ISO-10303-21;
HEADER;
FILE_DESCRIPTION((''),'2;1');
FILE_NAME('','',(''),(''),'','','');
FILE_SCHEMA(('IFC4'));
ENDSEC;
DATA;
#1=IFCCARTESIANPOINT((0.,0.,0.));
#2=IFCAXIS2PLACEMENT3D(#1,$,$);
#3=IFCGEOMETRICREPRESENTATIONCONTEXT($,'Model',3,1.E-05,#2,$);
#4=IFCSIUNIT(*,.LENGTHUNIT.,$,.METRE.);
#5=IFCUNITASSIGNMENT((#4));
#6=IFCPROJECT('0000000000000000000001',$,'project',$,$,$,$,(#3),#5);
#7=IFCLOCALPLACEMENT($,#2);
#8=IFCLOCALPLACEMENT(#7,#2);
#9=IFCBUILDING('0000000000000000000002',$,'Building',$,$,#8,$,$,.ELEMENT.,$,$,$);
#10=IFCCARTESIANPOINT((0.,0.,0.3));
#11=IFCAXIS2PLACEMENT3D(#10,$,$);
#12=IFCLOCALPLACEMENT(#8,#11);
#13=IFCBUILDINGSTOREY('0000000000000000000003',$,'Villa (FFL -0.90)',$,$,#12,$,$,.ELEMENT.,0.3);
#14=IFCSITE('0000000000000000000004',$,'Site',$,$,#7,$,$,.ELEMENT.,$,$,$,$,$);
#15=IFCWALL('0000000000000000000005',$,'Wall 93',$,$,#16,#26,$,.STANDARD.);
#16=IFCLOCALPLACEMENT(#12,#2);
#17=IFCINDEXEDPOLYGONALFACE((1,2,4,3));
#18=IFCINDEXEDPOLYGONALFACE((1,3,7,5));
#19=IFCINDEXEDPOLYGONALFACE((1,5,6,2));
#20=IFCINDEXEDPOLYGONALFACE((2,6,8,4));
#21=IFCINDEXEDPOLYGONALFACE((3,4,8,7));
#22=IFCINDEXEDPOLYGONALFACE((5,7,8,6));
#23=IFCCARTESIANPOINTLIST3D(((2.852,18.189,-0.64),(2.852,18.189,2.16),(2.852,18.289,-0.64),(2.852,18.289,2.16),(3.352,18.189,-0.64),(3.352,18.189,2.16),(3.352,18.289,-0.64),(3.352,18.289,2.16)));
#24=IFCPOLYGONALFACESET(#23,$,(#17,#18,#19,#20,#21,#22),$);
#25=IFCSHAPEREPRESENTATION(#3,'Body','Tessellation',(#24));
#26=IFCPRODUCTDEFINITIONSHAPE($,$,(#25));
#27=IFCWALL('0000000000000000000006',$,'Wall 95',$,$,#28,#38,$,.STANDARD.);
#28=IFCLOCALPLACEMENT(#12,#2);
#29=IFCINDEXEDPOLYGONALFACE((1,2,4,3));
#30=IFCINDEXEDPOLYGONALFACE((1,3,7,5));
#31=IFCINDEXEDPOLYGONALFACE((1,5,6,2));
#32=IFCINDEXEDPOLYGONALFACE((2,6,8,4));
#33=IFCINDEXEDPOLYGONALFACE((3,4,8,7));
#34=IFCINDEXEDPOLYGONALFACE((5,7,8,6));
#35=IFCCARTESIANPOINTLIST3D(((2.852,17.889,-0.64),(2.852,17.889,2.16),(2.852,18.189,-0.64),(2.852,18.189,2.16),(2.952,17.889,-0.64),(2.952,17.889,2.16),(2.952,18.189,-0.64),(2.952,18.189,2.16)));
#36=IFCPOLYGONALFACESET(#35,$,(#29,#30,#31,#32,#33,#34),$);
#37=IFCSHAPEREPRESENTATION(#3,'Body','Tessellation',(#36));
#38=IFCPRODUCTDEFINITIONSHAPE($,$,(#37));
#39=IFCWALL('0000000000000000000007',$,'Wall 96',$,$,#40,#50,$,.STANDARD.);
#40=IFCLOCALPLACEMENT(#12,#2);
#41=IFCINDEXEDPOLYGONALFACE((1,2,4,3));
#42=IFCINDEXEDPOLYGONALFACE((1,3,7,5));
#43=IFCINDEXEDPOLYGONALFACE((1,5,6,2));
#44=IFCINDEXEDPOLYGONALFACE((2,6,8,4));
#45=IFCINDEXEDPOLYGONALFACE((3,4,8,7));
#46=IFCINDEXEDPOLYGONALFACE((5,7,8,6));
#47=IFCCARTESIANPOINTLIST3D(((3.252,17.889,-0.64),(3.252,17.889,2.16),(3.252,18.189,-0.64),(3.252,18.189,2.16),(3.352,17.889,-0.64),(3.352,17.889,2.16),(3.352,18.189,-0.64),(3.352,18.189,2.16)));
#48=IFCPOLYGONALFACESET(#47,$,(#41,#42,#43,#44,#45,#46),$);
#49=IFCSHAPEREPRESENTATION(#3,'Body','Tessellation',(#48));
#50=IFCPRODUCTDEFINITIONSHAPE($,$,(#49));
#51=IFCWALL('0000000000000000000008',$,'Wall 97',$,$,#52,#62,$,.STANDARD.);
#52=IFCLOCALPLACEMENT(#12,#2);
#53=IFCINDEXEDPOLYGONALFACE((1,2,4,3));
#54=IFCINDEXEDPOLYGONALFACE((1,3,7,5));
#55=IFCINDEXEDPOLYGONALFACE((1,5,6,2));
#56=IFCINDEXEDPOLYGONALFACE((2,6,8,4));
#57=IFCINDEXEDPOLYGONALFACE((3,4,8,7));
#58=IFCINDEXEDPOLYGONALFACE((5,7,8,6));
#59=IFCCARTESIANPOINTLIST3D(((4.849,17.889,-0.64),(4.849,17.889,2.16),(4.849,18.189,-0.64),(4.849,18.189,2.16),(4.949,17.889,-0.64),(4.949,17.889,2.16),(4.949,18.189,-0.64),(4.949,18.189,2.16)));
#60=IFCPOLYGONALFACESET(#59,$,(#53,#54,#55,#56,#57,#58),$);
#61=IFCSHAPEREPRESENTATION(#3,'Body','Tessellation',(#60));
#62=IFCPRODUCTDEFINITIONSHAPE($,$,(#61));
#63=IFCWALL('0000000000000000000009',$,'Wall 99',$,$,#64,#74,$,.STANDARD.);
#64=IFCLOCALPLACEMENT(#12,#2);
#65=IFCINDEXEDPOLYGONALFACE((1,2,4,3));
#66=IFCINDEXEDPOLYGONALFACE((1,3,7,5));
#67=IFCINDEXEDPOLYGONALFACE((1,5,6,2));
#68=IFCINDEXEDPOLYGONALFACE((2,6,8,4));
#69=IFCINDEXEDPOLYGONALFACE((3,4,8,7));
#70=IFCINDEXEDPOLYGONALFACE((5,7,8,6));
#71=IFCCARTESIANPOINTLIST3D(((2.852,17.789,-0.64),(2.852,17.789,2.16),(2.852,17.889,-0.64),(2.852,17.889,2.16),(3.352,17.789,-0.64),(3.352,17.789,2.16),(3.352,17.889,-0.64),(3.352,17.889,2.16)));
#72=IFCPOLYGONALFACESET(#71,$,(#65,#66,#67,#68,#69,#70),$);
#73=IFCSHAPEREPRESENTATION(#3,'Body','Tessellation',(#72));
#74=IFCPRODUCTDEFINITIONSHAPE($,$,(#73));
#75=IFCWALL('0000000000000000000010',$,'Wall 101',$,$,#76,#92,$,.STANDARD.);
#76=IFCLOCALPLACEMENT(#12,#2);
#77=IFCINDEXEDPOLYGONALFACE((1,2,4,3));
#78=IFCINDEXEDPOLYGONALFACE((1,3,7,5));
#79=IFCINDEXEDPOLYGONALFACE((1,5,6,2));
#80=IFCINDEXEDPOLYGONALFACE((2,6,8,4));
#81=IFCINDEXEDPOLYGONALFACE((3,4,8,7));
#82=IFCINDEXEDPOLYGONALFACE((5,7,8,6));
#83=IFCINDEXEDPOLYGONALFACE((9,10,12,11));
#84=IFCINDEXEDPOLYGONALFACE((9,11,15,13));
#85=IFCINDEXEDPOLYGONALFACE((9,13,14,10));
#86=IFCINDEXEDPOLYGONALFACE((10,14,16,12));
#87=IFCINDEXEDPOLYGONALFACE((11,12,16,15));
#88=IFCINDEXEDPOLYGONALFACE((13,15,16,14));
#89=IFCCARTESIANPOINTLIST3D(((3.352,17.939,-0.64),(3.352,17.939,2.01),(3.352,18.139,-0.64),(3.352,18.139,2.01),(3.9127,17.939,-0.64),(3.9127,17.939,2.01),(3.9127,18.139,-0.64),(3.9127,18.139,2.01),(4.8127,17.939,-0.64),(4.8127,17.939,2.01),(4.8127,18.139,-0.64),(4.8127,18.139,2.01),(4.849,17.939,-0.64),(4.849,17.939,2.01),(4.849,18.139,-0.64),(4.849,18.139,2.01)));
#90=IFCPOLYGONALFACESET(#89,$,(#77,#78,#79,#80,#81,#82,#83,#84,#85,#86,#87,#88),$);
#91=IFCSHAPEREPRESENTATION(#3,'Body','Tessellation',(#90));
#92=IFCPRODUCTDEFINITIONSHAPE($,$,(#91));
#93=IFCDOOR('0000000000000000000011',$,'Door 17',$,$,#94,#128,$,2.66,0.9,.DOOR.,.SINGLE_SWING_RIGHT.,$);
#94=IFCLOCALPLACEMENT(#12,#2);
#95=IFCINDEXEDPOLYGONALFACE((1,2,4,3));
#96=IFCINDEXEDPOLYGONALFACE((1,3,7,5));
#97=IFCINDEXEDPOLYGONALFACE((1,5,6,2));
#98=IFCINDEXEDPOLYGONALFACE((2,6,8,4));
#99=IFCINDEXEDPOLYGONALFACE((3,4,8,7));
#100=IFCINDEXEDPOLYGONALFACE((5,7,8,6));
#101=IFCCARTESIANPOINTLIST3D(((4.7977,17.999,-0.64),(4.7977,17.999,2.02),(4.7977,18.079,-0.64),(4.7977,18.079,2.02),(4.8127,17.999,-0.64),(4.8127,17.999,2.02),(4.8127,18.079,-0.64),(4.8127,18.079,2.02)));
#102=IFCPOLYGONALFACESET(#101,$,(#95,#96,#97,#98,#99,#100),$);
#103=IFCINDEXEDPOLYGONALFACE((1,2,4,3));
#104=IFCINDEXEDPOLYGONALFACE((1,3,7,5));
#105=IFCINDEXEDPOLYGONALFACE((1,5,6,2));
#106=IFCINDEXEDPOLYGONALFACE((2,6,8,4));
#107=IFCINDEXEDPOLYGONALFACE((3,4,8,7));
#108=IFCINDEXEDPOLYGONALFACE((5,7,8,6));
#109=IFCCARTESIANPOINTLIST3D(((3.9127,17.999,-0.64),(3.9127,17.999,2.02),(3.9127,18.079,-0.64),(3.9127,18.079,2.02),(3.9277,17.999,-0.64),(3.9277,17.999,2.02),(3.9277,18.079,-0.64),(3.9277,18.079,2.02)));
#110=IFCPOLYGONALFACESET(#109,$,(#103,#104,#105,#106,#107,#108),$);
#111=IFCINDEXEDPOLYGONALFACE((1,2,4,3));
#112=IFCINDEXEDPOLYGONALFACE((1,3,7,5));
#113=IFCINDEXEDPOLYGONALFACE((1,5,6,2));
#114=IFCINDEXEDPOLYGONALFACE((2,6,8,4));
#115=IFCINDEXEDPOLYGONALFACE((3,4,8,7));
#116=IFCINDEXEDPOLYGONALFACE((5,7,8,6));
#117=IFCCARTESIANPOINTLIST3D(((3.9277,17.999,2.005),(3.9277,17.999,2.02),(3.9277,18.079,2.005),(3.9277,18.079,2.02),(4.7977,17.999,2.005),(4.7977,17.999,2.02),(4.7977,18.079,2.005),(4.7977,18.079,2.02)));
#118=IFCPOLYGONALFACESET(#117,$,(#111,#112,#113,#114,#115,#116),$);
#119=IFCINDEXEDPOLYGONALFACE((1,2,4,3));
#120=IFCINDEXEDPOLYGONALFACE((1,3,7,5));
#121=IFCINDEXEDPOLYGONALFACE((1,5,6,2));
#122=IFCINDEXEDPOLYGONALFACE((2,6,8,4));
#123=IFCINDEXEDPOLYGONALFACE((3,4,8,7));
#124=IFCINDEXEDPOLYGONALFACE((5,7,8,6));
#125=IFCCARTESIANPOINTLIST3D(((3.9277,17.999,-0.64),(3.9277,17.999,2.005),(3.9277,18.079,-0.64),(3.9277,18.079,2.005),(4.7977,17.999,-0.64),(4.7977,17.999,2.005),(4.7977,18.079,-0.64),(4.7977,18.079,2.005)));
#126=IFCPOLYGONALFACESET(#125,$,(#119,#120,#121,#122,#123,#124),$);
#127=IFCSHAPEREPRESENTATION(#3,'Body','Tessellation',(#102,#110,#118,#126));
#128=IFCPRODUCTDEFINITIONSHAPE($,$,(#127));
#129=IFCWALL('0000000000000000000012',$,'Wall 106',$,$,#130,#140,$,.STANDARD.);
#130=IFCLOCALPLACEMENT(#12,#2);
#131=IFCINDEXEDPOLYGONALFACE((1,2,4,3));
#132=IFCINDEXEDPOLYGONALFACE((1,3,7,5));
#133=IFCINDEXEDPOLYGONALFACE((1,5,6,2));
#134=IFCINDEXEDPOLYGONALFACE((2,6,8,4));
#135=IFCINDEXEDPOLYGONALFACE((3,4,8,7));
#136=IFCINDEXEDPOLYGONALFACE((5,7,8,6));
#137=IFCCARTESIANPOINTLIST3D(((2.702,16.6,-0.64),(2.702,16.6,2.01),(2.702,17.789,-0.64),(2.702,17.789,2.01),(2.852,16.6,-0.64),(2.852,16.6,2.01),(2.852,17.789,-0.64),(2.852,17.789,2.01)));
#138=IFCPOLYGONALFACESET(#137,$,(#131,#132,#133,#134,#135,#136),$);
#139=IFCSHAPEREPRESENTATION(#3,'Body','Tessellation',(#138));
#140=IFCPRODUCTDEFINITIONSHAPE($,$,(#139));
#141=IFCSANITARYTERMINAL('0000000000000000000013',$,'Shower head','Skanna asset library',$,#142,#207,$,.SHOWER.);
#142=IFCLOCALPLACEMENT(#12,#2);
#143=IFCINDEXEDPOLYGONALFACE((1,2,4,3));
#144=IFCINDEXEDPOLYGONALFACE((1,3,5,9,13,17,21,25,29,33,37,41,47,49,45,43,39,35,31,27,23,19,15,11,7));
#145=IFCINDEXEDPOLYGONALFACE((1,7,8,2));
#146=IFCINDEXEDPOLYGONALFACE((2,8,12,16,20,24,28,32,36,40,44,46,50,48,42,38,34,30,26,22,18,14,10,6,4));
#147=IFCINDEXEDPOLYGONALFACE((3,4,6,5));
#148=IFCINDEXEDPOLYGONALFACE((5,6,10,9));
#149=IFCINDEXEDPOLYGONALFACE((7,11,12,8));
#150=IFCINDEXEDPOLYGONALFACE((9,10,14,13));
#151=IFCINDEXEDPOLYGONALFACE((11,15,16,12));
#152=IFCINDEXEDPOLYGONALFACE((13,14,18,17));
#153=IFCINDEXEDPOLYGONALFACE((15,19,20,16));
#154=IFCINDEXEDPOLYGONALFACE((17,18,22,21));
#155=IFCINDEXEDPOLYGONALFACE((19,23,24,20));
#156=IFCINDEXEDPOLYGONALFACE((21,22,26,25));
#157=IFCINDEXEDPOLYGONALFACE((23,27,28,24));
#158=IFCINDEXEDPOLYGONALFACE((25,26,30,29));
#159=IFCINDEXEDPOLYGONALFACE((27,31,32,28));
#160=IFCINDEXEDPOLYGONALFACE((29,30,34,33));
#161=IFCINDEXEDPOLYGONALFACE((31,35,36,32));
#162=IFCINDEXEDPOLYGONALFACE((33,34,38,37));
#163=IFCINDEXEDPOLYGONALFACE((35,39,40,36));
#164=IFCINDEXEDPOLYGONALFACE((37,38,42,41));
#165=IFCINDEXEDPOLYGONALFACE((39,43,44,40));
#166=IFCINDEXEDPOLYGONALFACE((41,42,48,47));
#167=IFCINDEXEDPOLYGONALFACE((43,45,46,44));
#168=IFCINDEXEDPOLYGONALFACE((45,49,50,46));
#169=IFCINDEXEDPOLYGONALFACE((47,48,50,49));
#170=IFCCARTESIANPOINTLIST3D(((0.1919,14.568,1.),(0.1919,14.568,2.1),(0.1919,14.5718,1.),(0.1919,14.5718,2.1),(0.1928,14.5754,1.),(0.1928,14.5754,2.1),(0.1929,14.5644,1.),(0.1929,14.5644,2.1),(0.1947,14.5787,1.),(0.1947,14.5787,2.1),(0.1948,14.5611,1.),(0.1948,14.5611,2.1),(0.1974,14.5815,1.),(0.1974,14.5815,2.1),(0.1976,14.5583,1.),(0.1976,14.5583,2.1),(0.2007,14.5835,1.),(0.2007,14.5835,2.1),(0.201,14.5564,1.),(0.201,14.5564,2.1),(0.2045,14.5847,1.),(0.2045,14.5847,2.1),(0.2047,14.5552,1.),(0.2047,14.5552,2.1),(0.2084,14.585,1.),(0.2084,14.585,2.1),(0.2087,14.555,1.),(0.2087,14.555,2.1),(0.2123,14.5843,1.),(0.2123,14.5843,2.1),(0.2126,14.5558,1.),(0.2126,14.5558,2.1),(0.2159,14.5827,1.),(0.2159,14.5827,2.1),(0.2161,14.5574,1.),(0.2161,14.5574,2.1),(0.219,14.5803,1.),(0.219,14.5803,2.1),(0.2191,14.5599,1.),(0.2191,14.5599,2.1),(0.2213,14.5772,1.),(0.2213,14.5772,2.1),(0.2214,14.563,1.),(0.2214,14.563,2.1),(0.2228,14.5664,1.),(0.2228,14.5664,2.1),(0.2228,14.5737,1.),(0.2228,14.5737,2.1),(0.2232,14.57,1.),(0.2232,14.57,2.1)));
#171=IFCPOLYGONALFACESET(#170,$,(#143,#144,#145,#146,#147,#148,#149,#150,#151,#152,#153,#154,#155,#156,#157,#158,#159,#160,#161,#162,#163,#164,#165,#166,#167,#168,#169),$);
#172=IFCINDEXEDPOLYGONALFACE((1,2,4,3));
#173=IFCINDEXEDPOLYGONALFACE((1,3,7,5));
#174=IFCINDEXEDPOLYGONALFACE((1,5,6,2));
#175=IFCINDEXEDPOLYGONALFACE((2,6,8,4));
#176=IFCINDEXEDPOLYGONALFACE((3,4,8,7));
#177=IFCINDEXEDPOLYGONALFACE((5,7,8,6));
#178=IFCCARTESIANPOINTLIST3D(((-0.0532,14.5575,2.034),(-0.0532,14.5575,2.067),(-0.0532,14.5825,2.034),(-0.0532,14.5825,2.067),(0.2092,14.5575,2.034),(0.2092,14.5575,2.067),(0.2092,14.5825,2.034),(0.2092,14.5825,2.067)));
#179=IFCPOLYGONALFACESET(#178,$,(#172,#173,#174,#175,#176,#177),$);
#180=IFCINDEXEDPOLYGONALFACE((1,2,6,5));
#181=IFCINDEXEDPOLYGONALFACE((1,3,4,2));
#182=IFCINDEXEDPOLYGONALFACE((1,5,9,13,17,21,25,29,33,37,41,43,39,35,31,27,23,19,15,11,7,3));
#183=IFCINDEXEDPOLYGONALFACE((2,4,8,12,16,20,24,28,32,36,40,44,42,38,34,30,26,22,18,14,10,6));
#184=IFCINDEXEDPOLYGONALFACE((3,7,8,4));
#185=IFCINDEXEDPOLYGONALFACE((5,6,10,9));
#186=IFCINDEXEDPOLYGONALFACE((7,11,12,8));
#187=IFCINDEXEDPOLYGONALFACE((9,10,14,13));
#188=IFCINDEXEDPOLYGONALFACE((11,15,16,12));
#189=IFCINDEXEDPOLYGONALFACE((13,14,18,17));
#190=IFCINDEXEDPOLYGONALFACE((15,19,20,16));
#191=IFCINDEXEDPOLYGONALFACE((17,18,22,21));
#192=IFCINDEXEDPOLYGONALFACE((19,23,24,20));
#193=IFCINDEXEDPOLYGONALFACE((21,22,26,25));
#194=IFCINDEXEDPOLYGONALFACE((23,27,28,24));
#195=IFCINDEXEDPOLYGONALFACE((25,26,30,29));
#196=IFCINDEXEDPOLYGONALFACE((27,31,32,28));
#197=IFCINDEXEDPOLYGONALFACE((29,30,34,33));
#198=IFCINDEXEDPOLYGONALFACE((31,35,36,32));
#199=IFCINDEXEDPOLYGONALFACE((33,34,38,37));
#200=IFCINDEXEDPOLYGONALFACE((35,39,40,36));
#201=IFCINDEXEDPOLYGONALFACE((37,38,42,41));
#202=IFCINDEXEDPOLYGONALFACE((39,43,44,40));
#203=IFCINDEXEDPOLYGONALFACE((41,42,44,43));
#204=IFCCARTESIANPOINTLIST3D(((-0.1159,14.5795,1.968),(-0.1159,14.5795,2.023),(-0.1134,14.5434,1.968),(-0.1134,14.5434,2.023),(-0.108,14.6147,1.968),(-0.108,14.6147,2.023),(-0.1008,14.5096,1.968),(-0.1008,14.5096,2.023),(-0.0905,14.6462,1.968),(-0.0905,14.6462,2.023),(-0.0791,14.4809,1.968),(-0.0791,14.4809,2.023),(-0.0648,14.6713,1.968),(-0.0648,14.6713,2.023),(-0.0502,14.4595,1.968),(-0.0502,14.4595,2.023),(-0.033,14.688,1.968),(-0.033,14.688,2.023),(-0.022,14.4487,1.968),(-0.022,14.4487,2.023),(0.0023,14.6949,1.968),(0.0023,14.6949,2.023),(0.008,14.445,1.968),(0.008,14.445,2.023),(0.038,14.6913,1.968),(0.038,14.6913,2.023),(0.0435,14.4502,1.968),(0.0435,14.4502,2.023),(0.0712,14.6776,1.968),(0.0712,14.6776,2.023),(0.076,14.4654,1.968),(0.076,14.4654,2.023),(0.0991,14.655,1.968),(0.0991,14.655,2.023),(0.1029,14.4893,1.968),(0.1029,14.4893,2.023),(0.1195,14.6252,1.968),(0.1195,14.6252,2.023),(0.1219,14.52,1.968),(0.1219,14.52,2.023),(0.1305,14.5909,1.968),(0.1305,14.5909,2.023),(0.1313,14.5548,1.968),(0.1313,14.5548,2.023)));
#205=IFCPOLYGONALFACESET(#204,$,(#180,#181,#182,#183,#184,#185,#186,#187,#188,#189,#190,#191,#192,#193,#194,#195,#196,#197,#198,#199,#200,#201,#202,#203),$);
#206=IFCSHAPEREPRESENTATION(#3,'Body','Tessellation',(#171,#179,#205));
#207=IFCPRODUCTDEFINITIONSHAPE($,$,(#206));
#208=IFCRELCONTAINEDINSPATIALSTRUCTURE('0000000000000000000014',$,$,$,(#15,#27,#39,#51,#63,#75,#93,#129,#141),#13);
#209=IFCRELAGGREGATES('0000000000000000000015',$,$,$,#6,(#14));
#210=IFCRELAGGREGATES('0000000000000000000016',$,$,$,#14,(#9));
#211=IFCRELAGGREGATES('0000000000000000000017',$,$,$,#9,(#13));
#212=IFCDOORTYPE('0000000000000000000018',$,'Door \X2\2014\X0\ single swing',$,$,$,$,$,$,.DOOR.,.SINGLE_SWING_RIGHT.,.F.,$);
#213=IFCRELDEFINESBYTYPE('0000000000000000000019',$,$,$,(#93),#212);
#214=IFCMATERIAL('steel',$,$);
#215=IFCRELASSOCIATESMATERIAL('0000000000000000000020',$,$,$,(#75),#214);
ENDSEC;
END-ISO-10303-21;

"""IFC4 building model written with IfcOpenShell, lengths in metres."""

from ifc_helpers import new_model, si_unit, frame, frame_2d, origin, place, context, project, spatial, rectangle, ellipse, extrude, material, type_object, element, fill, save


model = new_model("IFC4")

# Units and contexts
model_context = context("Model", 3, precision=1e-05, world=origin())
ifc_project = project(units=[si_unit("LENGTHUNIT", "METRE")], contexts=[model_context])

# Site, building, storey
site_placement = place(None, origin())
site = spatial("IfcSite", under=ifc_project, at=site_placement, Name="Site", CompositionType="ELEMENT")
building_placement = place(site_placement, origin())
building = spatial("IfcBuilding", under=site, at=building_placement, Name="Building", CompositionType="ELEMENT")
storey_placement = place(building_placement, frame((0.0, 0.0, 0.3)))
storey = spatial("IfcBuildingStorey", under=building, at=storey_placement, Name="Villa (FFL -0.90)", CompositionType="ELEMENT", Elevation=0.3)

# Walls
wall_1_placement = place(storey_placement, frame((3.352, 18.239, -0.64), z_axis=(0.0, 0.0, 1.0), x_axis=(-1.0, 0.0, 0.0)))
element("IfcWall", 1, at=wall_1_placement, inside=storey, Name="Wall 93", PredefinedType="STANDARD", context=model_context, shape_type="SweptSolid", body=[
    extrude(rectangle(XDim=0.5, YDim=0.1, at=frame_2d((0.25, 0.0))), origin(), (0.0, 0.0, 1.0), 2.8),
])
for number, where, z_axis, x_axis, name in (
    (2, (2.902, 18.189, -0.64), (0.0, 0.0, 1.0), (0.0, -1.0, 0.0), "Wall 95"),
    (3, (3.302, 18.189, -0.64), (0.0, 0.0, 1.0), (0.0, -1.0, 0.0), "Wall 96"),
    (4, (4.899, 18.189, -0.64), (0.0, 0.0, 1.0), (0.0, -1.0, 0.0), "Wall 97"),
):
    element("IfcWall", number, at=place(storey_placement, frame(where, z_axis=z_axis, x_axis=x_axis)), inside=storey, Name=name, PredefinedType="STANDARD", context=model_context, shape_type="SweptSolid", body=[
        extrude(rectangle(XDim=0.3, YDim=0.1, at=frame_2d((0.15, 0.0))), origin(), (0.0, 0.0, 1.0), 2.8),
    ])
wall_2_placement = place(storey_placement, frame((3.352, 17.839, -0.64), z_axis=(0.0, 0.0, 1.0), x_axis=(-1.0, 0.0, 0.0)))
element("IfcWall", 5, at=wall_2_placement, inside=storey, Name="Wall 99", PredefinedType="STANDARD", context=model_context, shape_type="SweptSolid", body=[
    extrude(rectangle(XDim=0.5, YDim=0.1, at=frame_2d((0.25, 0.0))), origin(), (0.0, 0.0, 1.0), 2.8),
])

# Wall, opening, door
ifc_material = material(Name="steel")
wall_3_placement = place(storey_placement, frame((4.849, 18.039, -0.64), z_axis=(0.0, 0.0, 1.0), x_axis=(-1.0, 0.0, 0.0)))
wall_3 = element("IfcWall", 6, at=wall_3_placement, inside=storey, material=ifc_material, Name="Wall 101", PredefinedType="STANDARD", context=model_context, shape_type="SweptSolid", body=[
    extrude(rectangle(XDim=1.497, YDim=0.2, at=frame_2d((0.7485, 0.0))), origin(), (0.0, 0.0, 1.0), 2.65),
])
opening_1_placement = place(storey_placement, frame((4.8127, 18.039, -0.64), z_axis=(0.0, 0.0, 1.0), x_axis=(-1.0, 0.0, 0.0)))
opening_1 = element("IfcOpeningElement", 7, at=opening_1_placement, cuts=wall_3, PredefinedType="OPENING", context=model_context, shape_type="SweptSolid", body=[
    extrude(rectangle(XDim=0.9, YDim=0.26, at=frame_2d((0.45, 0.0))), origin(), (0.0, 0.0, 1.0), 2.66),
])
door_type_1 = type_object("IfcDoorType", Name="Door — single swing", OperationType="SINGLE_SWING_RIGHT", ParameterTakesPrecedence=False, PredefinedType="DOOR")
door_1_placement = place(storey_placement, frame((4.8127, 18.039, -0.64), z_axis=(0.0, 0.0, 1.0), x_axis=(-1.0, 0.0, 0.0)))
door_1 = element("IfcDoor", 8, at=door_1_placement, inside=storey, type_object=door_type_1, Name="Door 17", OperationType="SINGLE_SWING_RIGHT", OverallHeight=2.66, OverallWidth=0.9, PredefinedType="DOOR", context=model_context, shape_type="SweptSolid", body=[
    extrude(rectangle(XDim=0.015, YDim=0.08, at=frame_2d((0.0075, 0.0))), origin(), (0.0, 0.0, 1.0), 2.66),
    extrude(rectangle(XDim=0.015, YDim=0.08, at=frame_2d((0.8925, 0.0))), origin(), (0.0, 0.0, 1.0), 2.66),
    extrude(rectangle(XDim=0.87, YDim=0.08, at=frame_2d((0.45, 0.0))), frame((0.0, 0.0, 2.645)), (0.0, 0.0, 1.0), 0.015),
    extrude(rectangle(XDim=0.87, YDim=0.08, at=frame_2d((0.45, 0.0))), origin(), (0.0, 0.0, 1.0), 2.645),
])
fill(opening_1, door_1)

# Wall
wall_4_placement = place(storey_placement, frame((2.777, 16.6, -0.64), z_axis=(0.0, 0.0, 1.0), x_axis=(0.0, 1.0, 0.0)))
element("IfcWall", 9, at=wall_4_placement, inside=storey, Name="Wall 106", PredefinedType="STANDARD", context=model_context, shape_type="SweptSolid", body=[
    extrude(rectangle(XDim=1.189, YDim=0.15, at=frame_2d((0.5945, 0.0))), origin(), (0.0, 0.0, 1.0), 2.65),
])

# Sanitary terminal
for number, where, z_axis, x_axis, name in (
    (10, (0.0605, 14.57, 1.0), (0.0, 0.0, 1.0), (0.0, -1.0, 0.0), "Shower head"),
):
    element("IfcSanitaryTerminal", number, at=place(storey_placement, frame(where, z_axis=z_axis, x_axis=x_axis)), inside=storey, Name=name, Description="Skanna asset library", PredefinedType="SHOWER", context=model_context, shape_type="SweptSolid", body=[
        extrude(ellipse(SemiAxis1=0.015, SemiAxis2=0.0158, at=frame_2d((0.0, 0.147))), origin(), (0.0, 0.0, 1.0), 1.1),
        extrude(rectangle(XDim=0.025, YDim=0.2625, at=frame_2d((0.0, 0.0175))), frame((0.0, 0.0, 1.034)), (0.0, 0.0, 1.0), 0.033),
        extrude(ellipse(SemiAxis1=0.125, SemiAxis2=0.1242, at=frame_2d((0.0, -0.0525))), frame((0.0, 0.0, 0.968)), (0.0, 0.0, 1.0), 0.055),
    ])

save(model, "model.ifc")
